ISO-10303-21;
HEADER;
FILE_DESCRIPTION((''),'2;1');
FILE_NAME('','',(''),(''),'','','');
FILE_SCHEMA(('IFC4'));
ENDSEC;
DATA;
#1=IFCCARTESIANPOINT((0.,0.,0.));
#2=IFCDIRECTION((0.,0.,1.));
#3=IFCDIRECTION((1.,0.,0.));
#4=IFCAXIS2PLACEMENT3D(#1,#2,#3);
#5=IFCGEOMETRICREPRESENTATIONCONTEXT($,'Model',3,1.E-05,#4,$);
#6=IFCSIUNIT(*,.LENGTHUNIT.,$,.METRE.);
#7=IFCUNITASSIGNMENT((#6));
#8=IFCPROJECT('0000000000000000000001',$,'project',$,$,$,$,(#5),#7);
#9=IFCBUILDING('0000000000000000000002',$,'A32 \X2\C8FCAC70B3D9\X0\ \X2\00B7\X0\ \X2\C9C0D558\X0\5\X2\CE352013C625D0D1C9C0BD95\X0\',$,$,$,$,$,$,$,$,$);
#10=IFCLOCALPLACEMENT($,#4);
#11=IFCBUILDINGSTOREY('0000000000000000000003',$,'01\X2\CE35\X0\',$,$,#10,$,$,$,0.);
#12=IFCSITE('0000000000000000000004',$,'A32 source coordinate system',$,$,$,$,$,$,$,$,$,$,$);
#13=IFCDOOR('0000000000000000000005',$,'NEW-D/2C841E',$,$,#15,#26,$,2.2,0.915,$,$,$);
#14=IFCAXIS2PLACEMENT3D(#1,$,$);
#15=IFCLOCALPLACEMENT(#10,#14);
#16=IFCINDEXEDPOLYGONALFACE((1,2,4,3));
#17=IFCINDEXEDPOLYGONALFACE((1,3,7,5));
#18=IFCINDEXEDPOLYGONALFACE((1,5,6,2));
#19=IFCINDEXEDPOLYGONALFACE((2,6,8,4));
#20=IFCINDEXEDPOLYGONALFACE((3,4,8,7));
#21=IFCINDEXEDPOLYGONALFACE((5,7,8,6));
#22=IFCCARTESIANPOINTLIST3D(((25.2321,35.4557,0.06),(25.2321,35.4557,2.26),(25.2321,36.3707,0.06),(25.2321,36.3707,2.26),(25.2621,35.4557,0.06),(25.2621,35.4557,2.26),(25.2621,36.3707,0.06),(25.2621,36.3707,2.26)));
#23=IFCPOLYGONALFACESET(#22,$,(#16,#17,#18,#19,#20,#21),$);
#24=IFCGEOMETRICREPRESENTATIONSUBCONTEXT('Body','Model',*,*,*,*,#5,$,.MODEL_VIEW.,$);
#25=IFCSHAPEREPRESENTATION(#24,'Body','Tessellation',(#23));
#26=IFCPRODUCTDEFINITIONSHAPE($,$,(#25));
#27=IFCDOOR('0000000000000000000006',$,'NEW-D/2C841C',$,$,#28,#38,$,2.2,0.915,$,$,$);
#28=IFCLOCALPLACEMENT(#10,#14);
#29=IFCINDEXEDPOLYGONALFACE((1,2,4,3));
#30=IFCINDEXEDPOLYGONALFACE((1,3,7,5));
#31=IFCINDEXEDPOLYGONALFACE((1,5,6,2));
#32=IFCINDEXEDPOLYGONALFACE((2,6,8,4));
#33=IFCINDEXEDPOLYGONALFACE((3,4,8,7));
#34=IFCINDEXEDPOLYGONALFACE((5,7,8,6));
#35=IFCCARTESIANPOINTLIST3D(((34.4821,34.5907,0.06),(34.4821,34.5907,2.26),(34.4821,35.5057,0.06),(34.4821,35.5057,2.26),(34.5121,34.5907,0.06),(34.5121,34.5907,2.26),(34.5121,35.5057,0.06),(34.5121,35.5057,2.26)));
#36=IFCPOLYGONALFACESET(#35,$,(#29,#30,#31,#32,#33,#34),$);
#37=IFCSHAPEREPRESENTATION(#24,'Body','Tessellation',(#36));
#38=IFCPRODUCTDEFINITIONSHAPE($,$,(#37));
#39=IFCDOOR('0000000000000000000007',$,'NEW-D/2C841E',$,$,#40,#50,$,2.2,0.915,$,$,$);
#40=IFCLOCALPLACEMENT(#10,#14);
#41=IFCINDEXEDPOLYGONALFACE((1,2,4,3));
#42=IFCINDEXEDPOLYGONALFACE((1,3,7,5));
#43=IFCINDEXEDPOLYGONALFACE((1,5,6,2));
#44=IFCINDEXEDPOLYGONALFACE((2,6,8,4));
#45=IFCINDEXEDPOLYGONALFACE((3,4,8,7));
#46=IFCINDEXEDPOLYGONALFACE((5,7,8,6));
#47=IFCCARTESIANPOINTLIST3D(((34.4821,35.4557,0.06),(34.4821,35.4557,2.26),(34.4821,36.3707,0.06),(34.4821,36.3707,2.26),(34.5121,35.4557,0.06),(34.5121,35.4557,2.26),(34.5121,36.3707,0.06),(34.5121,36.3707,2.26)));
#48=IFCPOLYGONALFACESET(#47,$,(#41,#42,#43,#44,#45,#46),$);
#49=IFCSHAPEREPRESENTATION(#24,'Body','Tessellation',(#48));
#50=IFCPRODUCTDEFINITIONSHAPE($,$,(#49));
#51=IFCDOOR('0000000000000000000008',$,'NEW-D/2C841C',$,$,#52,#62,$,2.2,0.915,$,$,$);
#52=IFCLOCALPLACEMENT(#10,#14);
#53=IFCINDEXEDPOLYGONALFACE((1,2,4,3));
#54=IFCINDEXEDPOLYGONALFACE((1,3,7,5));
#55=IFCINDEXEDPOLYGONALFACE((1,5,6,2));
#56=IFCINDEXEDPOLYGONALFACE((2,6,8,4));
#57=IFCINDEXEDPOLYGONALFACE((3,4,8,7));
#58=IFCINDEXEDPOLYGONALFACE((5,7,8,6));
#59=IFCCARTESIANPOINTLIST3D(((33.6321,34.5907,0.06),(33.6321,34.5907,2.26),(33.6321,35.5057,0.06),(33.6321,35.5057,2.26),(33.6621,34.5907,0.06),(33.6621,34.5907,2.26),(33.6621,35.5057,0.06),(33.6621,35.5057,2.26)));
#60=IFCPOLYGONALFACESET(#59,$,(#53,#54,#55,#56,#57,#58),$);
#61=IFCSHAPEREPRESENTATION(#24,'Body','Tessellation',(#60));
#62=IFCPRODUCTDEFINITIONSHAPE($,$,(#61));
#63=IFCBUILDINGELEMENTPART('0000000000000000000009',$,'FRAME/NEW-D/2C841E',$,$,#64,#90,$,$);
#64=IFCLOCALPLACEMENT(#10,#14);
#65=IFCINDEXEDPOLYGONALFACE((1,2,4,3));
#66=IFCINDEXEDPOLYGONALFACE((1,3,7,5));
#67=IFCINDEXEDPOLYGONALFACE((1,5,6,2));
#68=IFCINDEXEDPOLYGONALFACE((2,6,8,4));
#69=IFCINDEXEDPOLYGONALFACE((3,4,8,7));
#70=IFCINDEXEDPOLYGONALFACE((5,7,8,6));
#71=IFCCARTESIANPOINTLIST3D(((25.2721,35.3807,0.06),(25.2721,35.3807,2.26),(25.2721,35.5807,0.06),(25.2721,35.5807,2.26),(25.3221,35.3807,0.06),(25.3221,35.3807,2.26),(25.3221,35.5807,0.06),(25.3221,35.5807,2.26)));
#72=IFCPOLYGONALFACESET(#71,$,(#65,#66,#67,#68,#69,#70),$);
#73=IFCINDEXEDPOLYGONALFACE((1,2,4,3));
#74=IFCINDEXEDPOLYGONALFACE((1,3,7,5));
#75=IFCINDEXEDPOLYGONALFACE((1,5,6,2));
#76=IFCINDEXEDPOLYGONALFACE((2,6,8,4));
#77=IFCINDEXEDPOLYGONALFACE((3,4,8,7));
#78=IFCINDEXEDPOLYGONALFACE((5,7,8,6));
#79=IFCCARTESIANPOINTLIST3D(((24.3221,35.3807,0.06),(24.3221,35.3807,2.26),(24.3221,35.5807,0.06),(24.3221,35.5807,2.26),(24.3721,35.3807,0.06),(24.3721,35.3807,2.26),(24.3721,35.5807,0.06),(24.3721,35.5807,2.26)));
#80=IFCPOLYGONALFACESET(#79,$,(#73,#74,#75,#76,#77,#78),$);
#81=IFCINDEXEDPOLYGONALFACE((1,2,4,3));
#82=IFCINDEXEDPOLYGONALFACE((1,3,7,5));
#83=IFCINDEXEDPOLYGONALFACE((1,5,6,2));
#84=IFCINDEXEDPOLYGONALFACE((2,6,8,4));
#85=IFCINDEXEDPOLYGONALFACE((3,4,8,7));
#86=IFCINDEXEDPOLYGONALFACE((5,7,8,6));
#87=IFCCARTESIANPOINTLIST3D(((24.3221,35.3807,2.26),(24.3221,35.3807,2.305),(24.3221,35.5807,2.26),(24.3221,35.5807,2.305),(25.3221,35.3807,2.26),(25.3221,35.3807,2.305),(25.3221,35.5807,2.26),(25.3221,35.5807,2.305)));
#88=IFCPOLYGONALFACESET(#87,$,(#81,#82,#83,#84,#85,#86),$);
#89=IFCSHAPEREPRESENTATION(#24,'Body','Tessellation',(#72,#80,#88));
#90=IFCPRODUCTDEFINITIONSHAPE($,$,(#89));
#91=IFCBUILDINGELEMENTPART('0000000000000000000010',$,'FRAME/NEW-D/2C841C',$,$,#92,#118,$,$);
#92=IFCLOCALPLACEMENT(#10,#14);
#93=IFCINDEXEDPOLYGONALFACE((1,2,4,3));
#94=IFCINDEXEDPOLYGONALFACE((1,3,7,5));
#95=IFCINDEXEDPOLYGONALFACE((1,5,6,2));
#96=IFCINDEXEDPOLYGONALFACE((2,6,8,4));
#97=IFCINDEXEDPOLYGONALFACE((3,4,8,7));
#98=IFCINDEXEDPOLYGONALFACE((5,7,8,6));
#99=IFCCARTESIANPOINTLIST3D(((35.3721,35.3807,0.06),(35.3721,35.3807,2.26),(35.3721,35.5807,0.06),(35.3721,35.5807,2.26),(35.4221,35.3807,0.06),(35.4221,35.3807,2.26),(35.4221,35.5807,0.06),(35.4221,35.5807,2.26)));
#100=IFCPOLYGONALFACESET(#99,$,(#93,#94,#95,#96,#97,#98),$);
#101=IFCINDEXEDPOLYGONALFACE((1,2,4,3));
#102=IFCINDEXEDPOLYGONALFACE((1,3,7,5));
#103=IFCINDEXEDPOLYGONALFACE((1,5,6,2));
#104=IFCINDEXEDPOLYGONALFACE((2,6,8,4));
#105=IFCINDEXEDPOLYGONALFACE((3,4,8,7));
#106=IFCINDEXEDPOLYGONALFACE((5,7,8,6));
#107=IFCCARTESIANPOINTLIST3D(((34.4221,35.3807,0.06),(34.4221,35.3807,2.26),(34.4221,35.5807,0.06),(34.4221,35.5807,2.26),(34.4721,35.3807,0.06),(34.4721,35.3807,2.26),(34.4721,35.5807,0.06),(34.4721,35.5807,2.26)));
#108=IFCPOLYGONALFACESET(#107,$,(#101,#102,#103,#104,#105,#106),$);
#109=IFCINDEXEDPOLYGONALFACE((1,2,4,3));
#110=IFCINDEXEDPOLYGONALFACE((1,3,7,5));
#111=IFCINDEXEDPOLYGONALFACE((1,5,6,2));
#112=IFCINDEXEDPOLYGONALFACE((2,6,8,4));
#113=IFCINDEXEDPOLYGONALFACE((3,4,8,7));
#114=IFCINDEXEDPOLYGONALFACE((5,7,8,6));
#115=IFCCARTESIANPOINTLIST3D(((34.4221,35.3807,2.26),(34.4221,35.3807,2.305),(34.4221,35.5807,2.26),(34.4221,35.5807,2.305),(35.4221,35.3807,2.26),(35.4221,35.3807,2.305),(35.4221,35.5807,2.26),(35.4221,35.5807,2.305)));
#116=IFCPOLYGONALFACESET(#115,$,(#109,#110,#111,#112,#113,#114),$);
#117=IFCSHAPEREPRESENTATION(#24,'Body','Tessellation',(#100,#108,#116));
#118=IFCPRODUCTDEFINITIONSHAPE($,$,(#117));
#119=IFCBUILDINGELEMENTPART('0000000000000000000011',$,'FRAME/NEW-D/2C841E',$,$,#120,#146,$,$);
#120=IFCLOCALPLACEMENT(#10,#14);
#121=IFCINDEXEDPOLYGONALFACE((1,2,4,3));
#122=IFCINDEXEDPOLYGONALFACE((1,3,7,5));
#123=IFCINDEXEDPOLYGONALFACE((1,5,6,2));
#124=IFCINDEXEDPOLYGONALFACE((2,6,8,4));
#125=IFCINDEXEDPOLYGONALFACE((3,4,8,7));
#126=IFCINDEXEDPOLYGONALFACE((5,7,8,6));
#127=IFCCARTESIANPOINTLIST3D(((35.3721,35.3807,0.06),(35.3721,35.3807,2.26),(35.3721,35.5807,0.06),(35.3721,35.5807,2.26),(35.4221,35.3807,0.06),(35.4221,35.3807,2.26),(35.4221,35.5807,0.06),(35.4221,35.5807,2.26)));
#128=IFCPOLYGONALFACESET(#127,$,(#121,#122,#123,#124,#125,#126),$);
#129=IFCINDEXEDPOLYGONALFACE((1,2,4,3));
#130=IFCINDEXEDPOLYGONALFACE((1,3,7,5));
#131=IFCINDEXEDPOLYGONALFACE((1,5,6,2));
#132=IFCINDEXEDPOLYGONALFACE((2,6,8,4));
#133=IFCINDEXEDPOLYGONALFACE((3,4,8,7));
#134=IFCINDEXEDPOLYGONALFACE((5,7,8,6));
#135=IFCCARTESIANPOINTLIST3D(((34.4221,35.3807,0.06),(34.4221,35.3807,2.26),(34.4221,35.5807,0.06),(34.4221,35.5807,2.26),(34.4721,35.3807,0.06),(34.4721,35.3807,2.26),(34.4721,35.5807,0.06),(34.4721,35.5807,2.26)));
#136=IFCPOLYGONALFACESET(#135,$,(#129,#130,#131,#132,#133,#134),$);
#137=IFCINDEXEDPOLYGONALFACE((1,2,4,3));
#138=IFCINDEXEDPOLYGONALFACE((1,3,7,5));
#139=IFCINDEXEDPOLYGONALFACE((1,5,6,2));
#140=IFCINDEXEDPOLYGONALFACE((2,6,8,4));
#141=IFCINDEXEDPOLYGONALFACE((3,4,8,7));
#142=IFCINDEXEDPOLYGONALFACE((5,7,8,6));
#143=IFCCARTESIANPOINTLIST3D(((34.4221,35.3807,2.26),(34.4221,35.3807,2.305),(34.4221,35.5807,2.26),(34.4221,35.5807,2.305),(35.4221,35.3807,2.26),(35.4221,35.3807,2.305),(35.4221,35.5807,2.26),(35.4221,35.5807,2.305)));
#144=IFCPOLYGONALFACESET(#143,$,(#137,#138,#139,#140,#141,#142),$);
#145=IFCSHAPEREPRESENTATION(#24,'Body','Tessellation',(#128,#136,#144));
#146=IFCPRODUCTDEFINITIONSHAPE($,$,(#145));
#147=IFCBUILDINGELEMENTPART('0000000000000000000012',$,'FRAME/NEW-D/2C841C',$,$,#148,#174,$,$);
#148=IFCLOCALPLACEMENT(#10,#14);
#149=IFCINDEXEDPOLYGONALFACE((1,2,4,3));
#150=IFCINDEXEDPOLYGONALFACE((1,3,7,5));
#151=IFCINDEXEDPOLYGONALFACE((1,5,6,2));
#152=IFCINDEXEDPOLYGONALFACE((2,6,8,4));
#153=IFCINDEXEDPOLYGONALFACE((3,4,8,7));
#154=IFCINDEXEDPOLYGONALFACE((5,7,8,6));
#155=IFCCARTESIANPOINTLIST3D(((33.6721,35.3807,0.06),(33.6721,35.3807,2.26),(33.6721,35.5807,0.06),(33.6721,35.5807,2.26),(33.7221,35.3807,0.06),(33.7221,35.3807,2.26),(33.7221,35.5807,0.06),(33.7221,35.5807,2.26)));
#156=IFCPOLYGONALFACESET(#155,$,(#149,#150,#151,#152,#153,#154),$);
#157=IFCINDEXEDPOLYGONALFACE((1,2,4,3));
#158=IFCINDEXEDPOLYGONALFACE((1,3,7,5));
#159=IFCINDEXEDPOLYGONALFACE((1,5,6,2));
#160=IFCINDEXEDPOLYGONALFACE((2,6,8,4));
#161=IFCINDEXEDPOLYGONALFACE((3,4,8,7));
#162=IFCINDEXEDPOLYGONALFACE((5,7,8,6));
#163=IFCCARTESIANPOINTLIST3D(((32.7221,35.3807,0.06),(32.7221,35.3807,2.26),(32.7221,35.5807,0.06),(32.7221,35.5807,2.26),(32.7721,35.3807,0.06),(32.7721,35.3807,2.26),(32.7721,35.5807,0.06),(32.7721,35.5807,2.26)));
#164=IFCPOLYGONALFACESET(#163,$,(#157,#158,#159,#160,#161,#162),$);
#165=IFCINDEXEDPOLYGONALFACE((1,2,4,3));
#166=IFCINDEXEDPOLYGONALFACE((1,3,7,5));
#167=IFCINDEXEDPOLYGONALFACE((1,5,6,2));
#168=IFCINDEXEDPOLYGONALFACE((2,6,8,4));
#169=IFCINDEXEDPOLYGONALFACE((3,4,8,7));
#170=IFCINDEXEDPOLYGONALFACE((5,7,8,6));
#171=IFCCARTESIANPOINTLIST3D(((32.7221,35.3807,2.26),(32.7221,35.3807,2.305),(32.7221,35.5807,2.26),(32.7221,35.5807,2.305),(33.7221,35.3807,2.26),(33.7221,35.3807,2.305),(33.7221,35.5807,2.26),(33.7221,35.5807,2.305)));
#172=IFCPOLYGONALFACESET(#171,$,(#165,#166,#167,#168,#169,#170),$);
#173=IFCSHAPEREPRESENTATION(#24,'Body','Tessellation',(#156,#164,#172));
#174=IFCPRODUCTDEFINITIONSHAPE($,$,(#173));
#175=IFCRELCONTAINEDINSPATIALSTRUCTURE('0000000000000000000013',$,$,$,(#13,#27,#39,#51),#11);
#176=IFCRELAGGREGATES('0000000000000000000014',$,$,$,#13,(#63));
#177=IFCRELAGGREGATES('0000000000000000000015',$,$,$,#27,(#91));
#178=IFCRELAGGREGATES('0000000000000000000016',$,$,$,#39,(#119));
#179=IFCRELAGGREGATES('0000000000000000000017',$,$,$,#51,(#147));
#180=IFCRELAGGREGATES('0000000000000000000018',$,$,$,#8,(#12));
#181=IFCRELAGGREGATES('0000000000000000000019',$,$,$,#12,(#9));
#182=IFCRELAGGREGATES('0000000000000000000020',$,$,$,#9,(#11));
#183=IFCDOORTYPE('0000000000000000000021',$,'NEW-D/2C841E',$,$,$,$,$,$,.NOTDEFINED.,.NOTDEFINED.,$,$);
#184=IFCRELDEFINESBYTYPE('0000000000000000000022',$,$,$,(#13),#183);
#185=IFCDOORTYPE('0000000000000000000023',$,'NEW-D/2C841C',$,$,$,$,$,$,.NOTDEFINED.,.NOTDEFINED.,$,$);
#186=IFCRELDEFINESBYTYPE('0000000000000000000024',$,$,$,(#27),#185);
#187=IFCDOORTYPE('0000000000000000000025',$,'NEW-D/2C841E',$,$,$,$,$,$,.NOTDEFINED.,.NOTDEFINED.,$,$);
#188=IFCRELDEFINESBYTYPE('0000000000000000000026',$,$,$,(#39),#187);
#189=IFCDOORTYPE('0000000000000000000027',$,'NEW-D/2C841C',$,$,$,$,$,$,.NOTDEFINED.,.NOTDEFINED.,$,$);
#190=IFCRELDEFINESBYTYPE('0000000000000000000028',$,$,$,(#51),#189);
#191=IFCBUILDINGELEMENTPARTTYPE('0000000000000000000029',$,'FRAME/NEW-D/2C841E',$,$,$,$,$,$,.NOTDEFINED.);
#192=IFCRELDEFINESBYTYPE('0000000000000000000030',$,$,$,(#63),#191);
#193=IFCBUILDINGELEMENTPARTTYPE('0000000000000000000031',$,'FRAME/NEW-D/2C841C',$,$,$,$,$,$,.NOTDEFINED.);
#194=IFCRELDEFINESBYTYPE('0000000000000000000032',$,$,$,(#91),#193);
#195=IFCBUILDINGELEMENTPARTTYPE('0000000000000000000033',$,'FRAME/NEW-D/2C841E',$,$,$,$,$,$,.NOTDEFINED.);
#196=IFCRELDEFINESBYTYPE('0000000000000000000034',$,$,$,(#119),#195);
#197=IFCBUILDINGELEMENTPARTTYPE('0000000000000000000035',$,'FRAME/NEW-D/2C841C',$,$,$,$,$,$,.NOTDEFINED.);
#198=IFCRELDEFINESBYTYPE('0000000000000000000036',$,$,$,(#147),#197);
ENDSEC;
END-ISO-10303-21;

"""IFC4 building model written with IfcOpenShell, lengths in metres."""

from ifc_helpers import new_model, si_unit, frame, origin, origin_with_axes, place, context, subcontext, project, spatial, polyline, outline, extrude, source, transform, mapped, type_object, type_shapes, element, aggregate, save


model = new_model("IFC4")

# Units and contexts
model_context = context("Model", 3, precision=1e-05, world=origin_with_axes())
body_context = subcontext(model_context, "Body", "Model", "MODEL_VIEW")
ifc_project = project(units=[si_unit("LENGTHUNIT", "METRE")], contexts=[model_context])

# Site, building, storey
site = spatial("IfcSite", under=ifc_project, Name="A32 source coordinate system")
building = spatial("IfcBuilding", under=site, Name="A32 주거동 · 지하5층–옥탑지붕")
storey_placement = place(None, origin_with_axes())
storey = spatial("IfcBuildingStorey", under=building, at=storey_placement, Name="01층", Elevation=0.0)

# Doors
door_type_1 = type_object("IfcDoorType", Name="NEW-D/2C841E", OperationType="NOTDEFINED", PredefinedType="NOTDEFINED")
shared_shape_1 = source(origin(), body_context, "Body", "SweptSolid", [
    extrude(outline(polyline([(25.2321, 35.4557), (25.2321, 36.3707), (25.2621, 36.3707), (25.2621, 35.4557), (25.2321, 35.4557)])), frame((0.0, 0.0, 0.06)), (0.0, 0.0, 1.0), 2.2),
])
type_shapes(door_type_1, [shared_shape_1])
door_1_placement = place(storey_placement, origin_with_axes())
door_1 = element("IfcDoor", 1, at=door_1_placement, inside=storey, type_object=door_type_1, Name="NEW-D/2C841E", OverallHeight=2.2, OverallWidth=0.915, context=body_context, shape_type="MappedRepresentation", body=[
    mapped(shared_shape_1, transform((0.0, 0.0, 0.0), scale=1.0)),
])
door_type_2 = type_object("IfcDoorType", Name="NEW-D/2C841C", OperationType="NOTDEFINED", PredefinedType="NOTDEFINED")
shared_shape_2 = source(origin(), body_context, "Body", "SweptSolid", [
    extrude(outline(polyline([(34.5121, 35.5057), (34.5121, 34.5907), (34.4821, 34.5907), (34.4821, 35.5057), (34.5121, 35.5057)])), frame((0.0, 0.0, 0.06)), (0.0, 0.0, 1.0), 2.2),
])
type_shapes(door_type_2, [shared_shape_2])
door_2_placement = place(storey_placement, origin_with_axes())
door_2 = element("IfcDoor", 2, at=door_2_placement, inside=storey, type_object=door_type_2, Name="NEW-D/2C841C", OverallHeight=2.2, OverallWidth=0.915, context=body_context, shape_type="MappedRepresentation", body=[
    mapped(shared_shape_2, transform((0.0, 0.0, 0.0), scale=1.0)),
])
door_type_3 = type_object("IfcDoorType", Name="NEW-D/2C841E", OperationType="NOTDEFINED", PredefinedType="NOTDEFINED")
shared_shape_3 = source(origin(), body_context, "Body", "SweptSolid", [
    extrude(outline(polyline([(34.4821, 36.3707), (34.5121, 36.3707), (34.5121, 35.4557), (34.4821, 35.4557), (34.4821, 36.3707)])), frame((0.0, 0.0, 0.06)), (0.0, 0.0, 1.0), 2.2),
])
type_shapes(door_type_3, [shared_shape_3])
door_3_placement = place(storey_placement, origin_with_axes())
door_3 = element("IfcDoor", 3, at=door_3_placement, inside=storey, type_object=door_type_3, Name="NEW-D/2C841E", OverallHeight=2.2, OverallWidth=0.915, context=body_context, shape_type="MappedRepresentation", body=[
    mapped(shared_shape_3, transform((0.0, 0.0, 0.0), scale=1.0)),
])
door_type_4 = type_object("IfcDoorType", Name="NEW-D/2C841C", OperationType="NOTDEFINED", PredefinedType="NOTDEFINED")
shared_shape_4 = source(origin(), body_context, "Body", "SweptSolid", [
    extrude(outline(polyline([(33.6621, 34.5907), (33.6321, 34.5907), (33.6321, 35.5057), (33.6621, 35.5057), (33.6621, 34.5907)])), frame((0.0, 0.0, 0.06)), (0.0, 0.0, 1.0), 2.2),
])
type_shapes(door_type_4, [shared_shape_4])
door_4_placement = place(storey_placement, origin_with_axes())
door_4 = element("IfcDoor", 4, at=door_4_placement, inside=storey, type_object=door_type_4, Name="NEW-D/2C841C", OverallHeight=2.2, OverallWidth=0.915, context=body_context, shape_type="MappedRepresentation", body=[
    mapped(shared_shape_4, transform((0.0, 0.0, 0.0), scale=1.0)),
])

# Building element parts
building_element_part_type_1 = type_object("IfcBuildingElementPartType", Name="FRAME/NEW-D/2C841E", PredefinedType="NOTDEFINED")
shared_shape_5 = source(origin(), body_context, "Body", "SweptSolid", [
    extrude(outline(polyline([(25.2721, 35.5807), (25.3221, 35.5807), (25.3221, 35.3807), (25.2721, 35.3807), (25.2721, 35.5807)])), frame((0.0, 0.0, 0.06)), (0.0, 0.0, 1.0), 2.2),
    extrude(outline(polyline([(24.3221, 35.5807), (24.3721, 35.5807), (24.3721, 35.3807), (24.3221, 35.3807), (24.3221, 35.5807)])), frame((0.0, 0.0, 0.06)), (0.0, 0.0, 1.0), 2.2),
    extrude(outline(polyline([(25.3221, 35.3807), (25.3221, 35.5807), (24.3221, 35.5807), (24.3221, 35.3807), (25.3221, 35.3807)])), frame((0.0, 0.0, 2.26)), (0.0, 0.0, 1.0), 0.045),
])
type_shapes(building_element_part_type_1, [shared_shape_5])
building_element_part_1_placement = place(door_1_placement, origin_with_axes())
building_element_part_1 = element("IfcBuildingElementPart", 5, at=building_element_part_1_placement, type_object=building_element_part_type_1, Name="FRAME/NEW-D/2C841E", context=body_context, shape_type="MappedRepresentation", body=[
    mapped(shared_shape_5, transform((0.0, 0.0, 0.0), scale=1.0)),
])
aggregate(door_1, [building_element_part_1])
building_element_part_type_2 = type_object("IfcBuildingElementPartType", Name="FRAME/NEW-D/2C841C", PredefinedType="NOTDEFINED")
shared_shape_6 = source(origin(), body_context, "Body", "SweptSolid", [
    extrude(outline(polyline([(35.4221, 35.5807), (35.4221, 35.3807), (35.3721, 35.3807), (35.3721, 35.5807), (35.4221, 35.5807)])), frame((0.0, 0.0, 0.06)), (0.0, 0.0, 1.0), 2.2),
    extrude(outline(polyline([(34.4721, 35.5807), (34.4721, 35.3807), (34.4221, 35.3807), (34.4221, 35.5807), (34.4721, 35.5807)])), frame((0.0, 0.0, 0.06)), (0.0, 0.0, 1.0), 2.2),
    extrude(outline(polyline([(35.4221, 35.3807), (35.4221, 35.5807), (34.4221, 35.5807), (34.4221, 35.3807), (35.4221, 35.3807)])), frame((0.0, 0.0, 2.26)), (0.0, 0.0, 1.0), 0.045),
])
type_shapes(building_element_part_type_2, [shared_shape_6])
building_element_part_2_placement = place(door_2_placement, origin_with_axes())
building_element_part_2 = element("IfcBuildingElementPart", 6, at=building_element_part_2_placement, type_object=building_element_part_type_2, Name="FRAME/NEW-D/2C841C", context=body_context, shape_type="MappedRepresentation", body=[
    mapped(shared_shape_6, transform((0.0, 0.0, 0.0), scale=1.0)),
])
aggregate(door_2, [building_element_part_2])
building_element_part_type_3 = type_object("IfcBuildingElementPartType", Name="FRAME/NEW-D/2C841E", PredefinedType="NOTDEFINED")
shared_shape_7 = source(origin(), body_context, "Body", "SweptSolid", [
    extrude(outline(polyline([(35.4221, 35.5807), (35.4221, 35.3807), (35.3721, 35.3807), (35.3721, 35.5807), (35.4221, 35.5807)])), frame((0.0, 0.0, 0.06)), (0.0, 0.0, 1.0), 2.2),
    extrude(outline(polyline([(34.4721, 35.5807), (34.4721, 35.3807), (34.4221, 35.3807), (34.4221, 35.5807), (34.4721, 35.5807)])), frame((0.0, 0.0, 0.06)), (0.0, 0.0, 1.0), 2.2),
    extrude(outline(polyline([(35.4221, 35.3807), (35.4221, 35.5807), (34.4221, 35.5807), (34.4221, 35.3807), (35.4221, 35.3807)])), frame((0.0, 0.0, 2.26)), (0.0, 0.0, 1.0), 0.045),
])
type_shapes(building_element_part_type_3, [shared_shape_7])
building_element_part_3_placement = place(door_3_placement, origin_with_axes())
building_element_part_3 = element("IfcBuildingElementPart", 7, at=building_element_part_3_placement, type_object=building_element_part_type_3, Name="FRAME/NEW-D/2C841E", context=body_context, shape_type="MappedRepresentation", body=[
    mapped(shared_shape_7, transform((0.0, 0.0, 0.0), scale=1.0)),
])
aggregate(door_3, [building_element_part_3])
building_element_part_type_4 = type_object("IfcBuildingElementPartType", Name="FRAME/NEW-D/2C841C", PredefinedType="NOTDEFINED")
shared_shape_8 = source(origin(), body_context, "Body", "SweptSolid", [
    extrude(outline(polyline([(33.6721, 35.5807), (33.7221, 35.5807), (33.7221, 35.3807), (33.6721, 35.3807), (33.6721, 35.5807)])), frame((0.0, 0.0, 0.06)), (0.0, 0.0, 1.0), 2.2),
    extrude(outline(polyline([(32.7221, 35.5807), (32.7721, 35.5807), (32.7721, 35.3807), (32.7221, 35.3807), (32.7221, 35.5807)])), frame((0.0, 0.0, 0.06)), (0.0, 0.0, 1.0), 2.2),
    extrude(outline(polyline([(33.7221, 35.3807), (33.7221, 35.5807), (32.7221, 35.5807), (32.7221, 35.3807), (33.7221, 35.3807)])), frame((0.0, 0.0, 2.26)), (0.0, 0.0, 1.0), 0.045),
])
type_shapes(building_element_part_type_4, [shared_shape_8])
building_element_part_4_placement = place(door_4_placement, origin_with_axes())
building_element_part_4 = element("IfcBuildingElementPart", 8, at=building_element_part_4_placement, type_object=building_element_part_type_4, Name="FRAME/NEW-D/2C841C", context=body_context, shape_type="MappedRepresentation", body=[
    mapped(shared_shape_8, transform((0.0, 0.0, 0.0), scale=1.0)),
])
aggregate(door_4, [building_element_part_4])

save(model, "model.ifc")
